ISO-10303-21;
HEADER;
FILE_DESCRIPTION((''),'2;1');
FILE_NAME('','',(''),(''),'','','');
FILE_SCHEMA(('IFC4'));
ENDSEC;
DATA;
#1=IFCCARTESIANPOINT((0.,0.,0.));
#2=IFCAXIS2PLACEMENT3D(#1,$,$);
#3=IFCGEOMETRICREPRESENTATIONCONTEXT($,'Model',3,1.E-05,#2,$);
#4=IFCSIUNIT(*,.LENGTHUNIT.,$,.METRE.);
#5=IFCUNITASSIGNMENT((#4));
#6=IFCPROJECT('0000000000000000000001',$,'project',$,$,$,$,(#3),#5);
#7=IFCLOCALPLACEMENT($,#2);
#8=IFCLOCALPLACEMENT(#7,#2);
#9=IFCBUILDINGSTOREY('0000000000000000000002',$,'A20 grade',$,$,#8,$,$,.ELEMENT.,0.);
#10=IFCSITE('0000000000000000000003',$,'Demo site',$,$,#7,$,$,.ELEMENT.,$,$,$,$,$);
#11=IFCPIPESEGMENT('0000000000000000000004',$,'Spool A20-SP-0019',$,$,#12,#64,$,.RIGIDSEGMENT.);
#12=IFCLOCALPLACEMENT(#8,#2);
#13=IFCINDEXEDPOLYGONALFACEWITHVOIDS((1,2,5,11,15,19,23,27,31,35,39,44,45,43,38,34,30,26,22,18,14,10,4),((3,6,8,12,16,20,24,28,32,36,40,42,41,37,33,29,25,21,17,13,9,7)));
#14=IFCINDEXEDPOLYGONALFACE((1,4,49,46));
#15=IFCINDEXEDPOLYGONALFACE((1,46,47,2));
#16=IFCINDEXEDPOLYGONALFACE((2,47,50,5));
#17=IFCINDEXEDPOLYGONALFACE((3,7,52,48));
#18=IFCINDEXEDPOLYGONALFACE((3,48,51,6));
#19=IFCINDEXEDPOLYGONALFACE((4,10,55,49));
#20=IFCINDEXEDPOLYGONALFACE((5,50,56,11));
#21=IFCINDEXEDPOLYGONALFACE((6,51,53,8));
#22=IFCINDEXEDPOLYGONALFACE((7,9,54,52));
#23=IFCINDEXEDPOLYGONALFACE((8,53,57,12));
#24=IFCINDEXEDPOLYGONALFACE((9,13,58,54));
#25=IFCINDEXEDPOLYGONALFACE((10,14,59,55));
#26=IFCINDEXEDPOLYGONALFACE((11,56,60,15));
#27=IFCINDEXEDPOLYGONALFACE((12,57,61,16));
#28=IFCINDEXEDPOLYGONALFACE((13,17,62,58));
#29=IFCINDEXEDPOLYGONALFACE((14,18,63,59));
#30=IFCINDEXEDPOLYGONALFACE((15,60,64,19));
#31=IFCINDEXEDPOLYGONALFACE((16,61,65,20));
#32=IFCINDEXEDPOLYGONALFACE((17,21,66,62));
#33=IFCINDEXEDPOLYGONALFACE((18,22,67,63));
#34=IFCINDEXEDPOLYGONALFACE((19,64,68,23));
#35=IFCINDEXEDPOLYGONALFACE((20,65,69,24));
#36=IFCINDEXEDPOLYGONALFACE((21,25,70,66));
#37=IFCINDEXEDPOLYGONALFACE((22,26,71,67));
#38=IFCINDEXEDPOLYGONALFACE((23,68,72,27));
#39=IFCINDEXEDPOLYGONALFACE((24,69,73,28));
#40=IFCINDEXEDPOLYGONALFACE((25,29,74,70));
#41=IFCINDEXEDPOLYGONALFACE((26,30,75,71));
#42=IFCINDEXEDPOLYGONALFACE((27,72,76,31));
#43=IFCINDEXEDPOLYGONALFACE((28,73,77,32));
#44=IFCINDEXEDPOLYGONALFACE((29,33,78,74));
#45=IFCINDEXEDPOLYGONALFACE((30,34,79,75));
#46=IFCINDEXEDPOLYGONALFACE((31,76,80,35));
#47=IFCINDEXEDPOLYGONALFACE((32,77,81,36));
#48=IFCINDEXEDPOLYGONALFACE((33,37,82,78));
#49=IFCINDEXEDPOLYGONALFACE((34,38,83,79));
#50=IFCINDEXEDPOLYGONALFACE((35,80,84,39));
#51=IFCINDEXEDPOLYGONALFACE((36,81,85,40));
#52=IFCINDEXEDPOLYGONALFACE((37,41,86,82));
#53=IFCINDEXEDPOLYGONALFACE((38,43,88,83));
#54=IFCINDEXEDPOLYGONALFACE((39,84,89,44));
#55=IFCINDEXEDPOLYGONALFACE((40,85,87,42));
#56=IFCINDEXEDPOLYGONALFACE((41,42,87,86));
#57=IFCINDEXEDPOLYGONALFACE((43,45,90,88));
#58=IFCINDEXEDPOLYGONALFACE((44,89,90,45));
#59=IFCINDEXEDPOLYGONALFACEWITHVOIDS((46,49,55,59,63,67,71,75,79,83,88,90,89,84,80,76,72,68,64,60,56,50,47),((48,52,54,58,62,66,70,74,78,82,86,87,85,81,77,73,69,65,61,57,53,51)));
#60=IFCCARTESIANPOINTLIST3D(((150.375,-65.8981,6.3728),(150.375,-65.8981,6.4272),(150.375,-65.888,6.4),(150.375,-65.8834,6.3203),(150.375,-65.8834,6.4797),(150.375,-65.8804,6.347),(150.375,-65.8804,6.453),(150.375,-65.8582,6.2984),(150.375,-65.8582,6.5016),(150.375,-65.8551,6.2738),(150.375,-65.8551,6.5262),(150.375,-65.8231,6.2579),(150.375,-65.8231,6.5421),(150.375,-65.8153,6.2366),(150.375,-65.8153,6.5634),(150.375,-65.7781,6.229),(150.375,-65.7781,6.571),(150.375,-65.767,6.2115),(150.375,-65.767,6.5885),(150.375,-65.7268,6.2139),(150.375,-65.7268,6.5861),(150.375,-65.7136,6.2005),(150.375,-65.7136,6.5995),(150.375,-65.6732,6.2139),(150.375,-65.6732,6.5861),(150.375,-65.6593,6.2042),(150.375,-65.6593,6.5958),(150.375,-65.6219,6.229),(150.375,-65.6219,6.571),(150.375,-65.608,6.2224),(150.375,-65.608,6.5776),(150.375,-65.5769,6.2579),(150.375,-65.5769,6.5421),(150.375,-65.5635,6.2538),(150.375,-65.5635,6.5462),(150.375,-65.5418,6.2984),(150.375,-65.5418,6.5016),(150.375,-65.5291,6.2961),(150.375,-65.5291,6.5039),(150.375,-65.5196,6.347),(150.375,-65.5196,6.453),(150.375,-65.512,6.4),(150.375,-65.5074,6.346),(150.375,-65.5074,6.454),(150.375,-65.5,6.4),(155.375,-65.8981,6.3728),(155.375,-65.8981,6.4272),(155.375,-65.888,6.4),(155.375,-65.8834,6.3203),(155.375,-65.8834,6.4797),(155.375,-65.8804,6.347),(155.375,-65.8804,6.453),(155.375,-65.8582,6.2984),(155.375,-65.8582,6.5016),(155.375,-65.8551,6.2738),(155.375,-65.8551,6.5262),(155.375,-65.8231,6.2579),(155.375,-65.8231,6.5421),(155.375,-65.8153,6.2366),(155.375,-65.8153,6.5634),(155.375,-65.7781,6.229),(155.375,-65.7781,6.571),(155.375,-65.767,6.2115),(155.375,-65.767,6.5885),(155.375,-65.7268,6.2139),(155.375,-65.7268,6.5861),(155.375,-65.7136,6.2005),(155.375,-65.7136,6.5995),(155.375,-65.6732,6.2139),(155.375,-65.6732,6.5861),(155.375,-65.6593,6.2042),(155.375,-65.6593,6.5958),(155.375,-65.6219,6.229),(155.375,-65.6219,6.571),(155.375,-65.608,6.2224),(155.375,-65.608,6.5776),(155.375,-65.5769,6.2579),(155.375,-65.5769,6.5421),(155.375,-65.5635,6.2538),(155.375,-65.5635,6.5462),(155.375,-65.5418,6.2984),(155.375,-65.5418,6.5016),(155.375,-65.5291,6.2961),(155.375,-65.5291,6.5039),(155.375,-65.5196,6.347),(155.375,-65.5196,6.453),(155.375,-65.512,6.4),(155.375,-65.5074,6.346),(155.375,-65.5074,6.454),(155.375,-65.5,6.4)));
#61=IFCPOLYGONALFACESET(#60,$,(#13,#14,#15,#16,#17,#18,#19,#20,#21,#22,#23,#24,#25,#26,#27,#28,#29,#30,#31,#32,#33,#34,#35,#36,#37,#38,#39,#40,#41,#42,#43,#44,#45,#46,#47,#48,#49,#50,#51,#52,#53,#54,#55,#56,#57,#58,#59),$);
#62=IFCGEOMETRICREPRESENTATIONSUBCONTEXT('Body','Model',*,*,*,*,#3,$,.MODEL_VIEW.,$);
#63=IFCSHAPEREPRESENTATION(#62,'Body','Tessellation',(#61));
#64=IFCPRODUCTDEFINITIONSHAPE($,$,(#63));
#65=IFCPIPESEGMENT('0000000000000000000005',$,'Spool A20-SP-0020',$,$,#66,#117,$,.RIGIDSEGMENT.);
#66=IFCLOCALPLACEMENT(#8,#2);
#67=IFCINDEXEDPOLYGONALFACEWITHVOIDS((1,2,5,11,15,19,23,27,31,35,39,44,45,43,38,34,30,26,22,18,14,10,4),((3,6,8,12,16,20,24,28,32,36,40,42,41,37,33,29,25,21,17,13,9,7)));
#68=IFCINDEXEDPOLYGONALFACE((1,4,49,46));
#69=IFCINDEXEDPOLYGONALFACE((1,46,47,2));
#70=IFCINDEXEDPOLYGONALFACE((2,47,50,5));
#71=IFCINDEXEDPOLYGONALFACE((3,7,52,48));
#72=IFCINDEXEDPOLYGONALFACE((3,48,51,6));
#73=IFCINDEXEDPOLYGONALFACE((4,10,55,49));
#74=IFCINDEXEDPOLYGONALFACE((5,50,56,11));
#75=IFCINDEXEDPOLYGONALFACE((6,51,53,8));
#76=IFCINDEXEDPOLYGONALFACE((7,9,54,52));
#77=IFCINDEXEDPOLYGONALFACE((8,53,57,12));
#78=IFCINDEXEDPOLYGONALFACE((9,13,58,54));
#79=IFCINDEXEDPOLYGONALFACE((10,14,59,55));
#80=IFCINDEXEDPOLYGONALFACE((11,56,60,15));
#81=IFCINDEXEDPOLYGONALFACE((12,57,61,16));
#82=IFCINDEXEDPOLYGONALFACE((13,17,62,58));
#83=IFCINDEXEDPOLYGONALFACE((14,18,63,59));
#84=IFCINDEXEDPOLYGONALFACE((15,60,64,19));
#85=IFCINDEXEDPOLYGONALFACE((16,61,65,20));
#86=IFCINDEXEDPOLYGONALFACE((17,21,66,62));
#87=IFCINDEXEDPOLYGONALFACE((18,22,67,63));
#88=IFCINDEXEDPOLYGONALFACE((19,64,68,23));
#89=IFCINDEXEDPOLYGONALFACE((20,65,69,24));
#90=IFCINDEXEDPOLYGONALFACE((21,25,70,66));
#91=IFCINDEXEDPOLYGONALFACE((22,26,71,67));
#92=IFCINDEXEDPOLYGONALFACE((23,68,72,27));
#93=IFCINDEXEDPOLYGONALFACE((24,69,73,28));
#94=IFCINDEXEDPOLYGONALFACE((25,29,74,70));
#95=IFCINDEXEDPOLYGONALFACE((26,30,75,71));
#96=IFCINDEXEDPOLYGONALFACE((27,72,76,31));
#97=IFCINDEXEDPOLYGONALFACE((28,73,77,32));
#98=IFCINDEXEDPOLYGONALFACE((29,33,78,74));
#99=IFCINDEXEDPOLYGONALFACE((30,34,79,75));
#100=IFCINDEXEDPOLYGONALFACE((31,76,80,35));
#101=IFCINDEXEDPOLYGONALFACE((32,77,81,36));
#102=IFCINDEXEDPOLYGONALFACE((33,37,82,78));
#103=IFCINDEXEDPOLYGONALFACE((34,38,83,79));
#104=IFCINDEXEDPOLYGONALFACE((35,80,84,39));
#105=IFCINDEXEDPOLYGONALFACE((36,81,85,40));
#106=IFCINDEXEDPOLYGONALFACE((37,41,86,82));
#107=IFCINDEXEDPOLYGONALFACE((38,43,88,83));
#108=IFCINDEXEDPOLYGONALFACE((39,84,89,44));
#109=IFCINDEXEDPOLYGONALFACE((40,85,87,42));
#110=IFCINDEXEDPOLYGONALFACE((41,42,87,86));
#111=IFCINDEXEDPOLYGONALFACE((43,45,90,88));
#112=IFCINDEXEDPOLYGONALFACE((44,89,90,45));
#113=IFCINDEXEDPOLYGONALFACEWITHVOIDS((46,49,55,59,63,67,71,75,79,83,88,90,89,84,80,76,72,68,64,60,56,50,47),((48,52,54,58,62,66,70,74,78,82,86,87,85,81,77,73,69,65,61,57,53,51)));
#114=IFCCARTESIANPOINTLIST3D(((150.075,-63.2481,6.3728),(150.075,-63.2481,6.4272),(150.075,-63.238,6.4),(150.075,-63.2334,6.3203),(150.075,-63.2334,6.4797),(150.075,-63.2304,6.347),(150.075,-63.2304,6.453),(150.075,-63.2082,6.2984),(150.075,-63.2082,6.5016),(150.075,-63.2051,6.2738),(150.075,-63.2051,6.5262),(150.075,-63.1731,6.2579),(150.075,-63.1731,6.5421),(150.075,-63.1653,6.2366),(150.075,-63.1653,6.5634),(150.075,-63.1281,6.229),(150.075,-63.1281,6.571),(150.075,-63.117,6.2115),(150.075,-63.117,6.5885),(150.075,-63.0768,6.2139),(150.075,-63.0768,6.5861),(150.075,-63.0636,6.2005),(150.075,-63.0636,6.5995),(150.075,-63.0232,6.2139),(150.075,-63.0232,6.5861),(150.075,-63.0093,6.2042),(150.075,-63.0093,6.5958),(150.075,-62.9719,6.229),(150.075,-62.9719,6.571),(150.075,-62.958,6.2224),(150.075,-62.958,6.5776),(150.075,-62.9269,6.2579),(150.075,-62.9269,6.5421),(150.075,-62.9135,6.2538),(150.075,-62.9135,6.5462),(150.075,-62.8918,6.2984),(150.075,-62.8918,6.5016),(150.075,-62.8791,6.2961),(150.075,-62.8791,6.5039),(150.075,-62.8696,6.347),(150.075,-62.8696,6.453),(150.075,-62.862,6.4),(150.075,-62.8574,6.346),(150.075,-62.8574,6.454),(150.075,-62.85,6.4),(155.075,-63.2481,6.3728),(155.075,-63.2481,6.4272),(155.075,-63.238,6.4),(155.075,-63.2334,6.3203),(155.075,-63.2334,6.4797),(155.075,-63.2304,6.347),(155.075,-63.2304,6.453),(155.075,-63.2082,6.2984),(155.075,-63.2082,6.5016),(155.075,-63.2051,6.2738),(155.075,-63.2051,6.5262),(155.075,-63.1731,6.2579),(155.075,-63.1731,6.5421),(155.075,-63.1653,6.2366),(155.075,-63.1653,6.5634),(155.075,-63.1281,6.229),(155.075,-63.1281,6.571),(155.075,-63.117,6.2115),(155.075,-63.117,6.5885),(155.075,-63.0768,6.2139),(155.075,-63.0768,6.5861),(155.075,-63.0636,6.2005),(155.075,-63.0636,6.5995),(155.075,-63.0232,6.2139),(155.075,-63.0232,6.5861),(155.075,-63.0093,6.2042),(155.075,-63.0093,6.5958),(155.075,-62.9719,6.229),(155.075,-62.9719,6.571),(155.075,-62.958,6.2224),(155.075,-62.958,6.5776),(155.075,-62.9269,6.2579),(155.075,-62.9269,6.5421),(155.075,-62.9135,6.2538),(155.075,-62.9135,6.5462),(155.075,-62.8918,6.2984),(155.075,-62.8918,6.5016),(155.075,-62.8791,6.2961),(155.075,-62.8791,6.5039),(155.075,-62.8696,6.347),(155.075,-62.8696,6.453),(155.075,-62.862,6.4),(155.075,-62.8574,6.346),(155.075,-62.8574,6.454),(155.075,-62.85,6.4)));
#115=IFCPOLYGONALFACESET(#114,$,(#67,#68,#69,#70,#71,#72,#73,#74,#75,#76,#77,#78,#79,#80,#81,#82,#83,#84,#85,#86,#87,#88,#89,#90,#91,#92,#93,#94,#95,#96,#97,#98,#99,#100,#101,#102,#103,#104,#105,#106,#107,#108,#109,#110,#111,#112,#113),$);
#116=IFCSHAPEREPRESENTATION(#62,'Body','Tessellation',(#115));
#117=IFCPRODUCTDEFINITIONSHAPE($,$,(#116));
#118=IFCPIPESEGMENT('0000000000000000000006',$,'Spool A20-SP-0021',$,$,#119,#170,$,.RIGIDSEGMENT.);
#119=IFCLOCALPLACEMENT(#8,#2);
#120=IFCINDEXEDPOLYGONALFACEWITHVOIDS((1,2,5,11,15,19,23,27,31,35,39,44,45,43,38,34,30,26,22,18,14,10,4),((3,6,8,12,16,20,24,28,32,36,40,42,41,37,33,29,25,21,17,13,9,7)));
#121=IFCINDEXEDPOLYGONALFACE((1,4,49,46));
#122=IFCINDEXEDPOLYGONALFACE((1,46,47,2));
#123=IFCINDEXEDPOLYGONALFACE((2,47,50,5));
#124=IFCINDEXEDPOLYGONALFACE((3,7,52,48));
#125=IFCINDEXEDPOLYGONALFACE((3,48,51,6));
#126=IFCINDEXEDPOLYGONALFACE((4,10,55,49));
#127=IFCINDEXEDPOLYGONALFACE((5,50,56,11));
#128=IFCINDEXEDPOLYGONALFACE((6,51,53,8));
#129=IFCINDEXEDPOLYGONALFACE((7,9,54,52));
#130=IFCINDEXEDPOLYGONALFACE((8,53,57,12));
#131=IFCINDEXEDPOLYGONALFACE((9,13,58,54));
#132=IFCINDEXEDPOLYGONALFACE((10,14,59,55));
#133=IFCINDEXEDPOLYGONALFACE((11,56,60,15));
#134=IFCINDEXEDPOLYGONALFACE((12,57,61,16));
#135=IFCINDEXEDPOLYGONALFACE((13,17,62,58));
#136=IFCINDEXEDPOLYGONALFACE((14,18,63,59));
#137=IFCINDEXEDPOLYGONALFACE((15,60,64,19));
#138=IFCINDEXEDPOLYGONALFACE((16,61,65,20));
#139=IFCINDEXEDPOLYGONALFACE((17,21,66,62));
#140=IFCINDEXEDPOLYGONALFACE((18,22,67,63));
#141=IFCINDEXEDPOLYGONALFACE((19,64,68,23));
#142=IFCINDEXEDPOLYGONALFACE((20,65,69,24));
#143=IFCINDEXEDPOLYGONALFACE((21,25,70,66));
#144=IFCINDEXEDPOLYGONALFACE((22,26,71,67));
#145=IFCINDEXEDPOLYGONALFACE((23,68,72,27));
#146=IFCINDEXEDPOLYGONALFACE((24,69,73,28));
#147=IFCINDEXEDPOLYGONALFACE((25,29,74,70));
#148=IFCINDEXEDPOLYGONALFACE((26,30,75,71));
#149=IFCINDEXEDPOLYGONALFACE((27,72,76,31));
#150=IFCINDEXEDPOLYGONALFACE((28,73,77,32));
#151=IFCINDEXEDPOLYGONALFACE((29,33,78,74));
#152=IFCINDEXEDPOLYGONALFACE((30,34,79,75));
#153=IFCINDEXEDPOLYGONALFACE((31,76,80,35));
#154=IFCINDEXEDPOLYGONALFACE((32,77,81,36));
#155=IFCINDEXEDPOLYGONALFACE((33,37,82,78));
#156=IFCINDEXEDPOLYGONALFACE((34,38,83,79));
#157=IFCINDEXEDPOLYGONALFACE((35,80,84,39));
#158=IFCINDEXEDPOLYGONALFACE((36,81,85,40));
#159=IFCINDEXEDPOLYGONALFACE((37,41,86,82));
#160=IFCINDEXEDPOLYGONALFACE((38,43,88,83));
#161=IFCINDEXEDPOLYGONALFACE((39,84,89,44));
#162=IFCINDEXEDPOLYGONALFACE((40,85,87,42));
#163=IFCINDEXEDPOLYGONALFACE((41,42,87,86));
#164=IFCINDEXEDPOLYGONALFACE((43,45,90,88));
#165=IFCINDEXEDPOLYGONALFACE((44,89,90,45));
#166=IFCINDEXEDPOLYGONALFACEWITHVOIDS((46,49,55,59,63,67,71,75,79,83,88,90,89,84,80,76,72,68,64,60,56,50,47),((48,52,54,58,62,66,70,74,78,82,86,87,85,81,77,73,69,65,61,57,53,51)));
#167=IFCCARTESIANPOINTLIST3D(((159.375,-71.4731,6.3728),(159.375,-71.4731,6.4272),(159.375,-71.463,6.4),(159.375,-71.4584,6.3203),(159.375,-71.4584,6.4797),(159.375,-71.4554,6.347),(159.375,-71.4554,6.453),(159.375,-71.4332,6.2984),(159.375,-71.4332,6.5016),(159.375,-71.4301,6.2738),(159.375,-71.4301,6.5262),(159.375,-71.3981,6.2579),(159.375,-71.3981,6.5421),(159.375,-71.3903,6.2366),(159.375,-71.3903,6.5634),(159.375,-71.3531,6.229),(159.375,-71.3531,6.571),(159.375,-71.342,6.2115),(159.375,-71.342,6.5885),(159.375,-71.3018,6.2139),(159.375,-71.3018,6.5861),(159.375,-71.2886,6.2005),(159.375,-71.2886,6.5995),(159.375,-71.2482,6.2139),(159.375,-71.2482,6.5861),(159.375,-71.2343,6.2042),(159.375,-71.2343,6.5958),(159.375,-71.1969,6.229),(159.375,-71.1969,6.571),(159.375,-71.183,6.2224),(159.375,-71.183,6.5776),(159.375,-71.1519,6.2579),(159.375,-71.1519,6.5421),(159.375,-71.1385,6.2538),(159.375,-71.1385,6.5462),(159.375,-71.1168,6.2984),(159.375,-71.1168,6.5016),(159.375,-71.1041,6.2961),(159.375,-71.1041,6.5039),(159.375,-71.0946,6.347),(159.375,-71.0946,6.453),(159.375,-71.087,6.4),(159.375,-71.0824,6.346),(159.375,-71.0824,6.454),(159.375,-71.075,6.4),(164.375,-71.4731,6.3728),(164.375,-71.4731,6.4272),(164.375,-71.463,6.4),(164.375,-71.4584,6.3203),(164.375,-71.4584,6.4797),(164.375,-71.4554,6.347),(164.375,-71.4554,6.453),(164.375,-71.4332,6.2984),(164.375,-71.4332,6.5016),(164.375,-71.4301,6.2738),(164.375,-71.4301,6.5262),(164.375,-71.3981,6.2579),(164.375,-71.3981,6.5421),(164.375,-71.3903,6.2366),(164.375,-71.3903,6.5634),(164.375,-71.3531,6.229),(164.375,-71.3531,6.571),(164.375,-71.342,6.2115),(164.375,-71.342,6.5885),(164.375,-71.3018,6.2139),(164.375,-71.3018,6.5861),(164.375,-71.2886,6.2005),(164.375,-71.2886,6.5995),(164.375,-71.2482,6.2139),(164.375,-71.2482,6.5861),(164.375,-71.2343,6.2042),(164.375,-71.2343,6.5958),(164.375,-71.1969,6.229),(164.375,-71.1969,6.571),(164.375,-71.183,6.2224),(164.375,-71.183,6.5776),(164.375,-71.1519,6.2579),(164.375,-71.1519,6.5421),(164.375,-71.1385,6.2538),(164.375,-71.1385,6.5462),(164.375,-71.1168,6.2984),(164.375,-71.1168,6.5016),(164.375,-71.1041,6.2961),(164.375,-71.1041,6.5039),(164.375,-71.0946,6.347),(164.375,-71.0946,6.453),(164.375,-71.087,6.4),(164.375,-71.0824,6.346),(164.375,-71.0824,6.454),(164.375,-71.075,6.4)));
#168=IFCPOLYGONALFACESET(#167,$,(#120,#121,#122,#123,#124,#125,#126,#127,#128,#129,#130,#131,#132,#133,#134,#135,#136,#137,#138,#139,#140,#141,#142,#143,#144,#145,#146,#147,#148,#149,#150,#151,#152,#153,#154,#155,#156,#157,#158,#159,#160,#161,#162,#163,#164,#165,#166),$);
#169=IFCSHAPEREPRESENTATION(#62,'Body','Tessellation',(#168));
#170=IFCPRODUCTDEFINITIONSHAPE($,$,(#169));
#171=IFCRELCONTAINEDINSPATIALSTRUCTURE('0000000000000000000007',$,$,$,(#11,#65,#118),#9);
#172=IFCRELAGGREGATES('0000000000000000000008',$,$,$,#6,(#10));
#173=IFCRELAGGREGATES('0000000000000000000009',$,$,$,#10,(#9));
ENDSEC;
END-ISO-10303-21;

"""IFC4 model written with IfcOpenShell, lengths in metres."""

from ifc_helpers import new_model, si_unit, frame, origin, place, context, subcontext, project, spatial, hollow_circle, extrude, element, save


model = new_model("IFC4")

# Units and contexts
model_context = context("Model", 3, precision=1e-05, world=origin())
body_context = subcontext(model_context, "Body", "Model", "MODEL_VIEW")
ifc_project = project(units=[si_unit("LENGTHUNIT", "METRE")], contexts=[model_context])

# Site, storey
site_placement = place(None, origin())
site = spatial("IfcSite", under=ifc_project, at=site_placement, Name="Demo site", CompositionType="ELEMENT")
storey_placement = place(site_placement, origin())
storey = spatial("IfcBuildingStorey", under=site, at=storey_placement, Name="A20 grade", CompositionType="ELEMENT", Elevation=0.0)

# Pipe segments
for number, where, name in (
    (1, (150.375, -65.7, 6.4), "Spool A20-SP-0019"),
    (2, (150.075, -63.05, 6.4), "Spool A20-SP-0020"),
    (3, (159.375, -71.275, 6.4), "Spool A20-SP-0021"),
):
    element("IfcPipeSegment", number, at=place(storey_placement, frame(where)), inside=storey, Name=name, PredefinedType="RIGIDSEGMENT", context=body_context, shape_type="SweptSolid", body=[
        extrude(hollow_circle(Radius=0.2, WallThickness=0.012), frame((0.0, 0.0, 0.0), z_axis=(1.0, 0.0, 0.0), x_axis=(0.0, 1.0, 0.0)), (0.0, 0.0, 1.0), 5.0),
    ])

save(model, "model.ifc")
